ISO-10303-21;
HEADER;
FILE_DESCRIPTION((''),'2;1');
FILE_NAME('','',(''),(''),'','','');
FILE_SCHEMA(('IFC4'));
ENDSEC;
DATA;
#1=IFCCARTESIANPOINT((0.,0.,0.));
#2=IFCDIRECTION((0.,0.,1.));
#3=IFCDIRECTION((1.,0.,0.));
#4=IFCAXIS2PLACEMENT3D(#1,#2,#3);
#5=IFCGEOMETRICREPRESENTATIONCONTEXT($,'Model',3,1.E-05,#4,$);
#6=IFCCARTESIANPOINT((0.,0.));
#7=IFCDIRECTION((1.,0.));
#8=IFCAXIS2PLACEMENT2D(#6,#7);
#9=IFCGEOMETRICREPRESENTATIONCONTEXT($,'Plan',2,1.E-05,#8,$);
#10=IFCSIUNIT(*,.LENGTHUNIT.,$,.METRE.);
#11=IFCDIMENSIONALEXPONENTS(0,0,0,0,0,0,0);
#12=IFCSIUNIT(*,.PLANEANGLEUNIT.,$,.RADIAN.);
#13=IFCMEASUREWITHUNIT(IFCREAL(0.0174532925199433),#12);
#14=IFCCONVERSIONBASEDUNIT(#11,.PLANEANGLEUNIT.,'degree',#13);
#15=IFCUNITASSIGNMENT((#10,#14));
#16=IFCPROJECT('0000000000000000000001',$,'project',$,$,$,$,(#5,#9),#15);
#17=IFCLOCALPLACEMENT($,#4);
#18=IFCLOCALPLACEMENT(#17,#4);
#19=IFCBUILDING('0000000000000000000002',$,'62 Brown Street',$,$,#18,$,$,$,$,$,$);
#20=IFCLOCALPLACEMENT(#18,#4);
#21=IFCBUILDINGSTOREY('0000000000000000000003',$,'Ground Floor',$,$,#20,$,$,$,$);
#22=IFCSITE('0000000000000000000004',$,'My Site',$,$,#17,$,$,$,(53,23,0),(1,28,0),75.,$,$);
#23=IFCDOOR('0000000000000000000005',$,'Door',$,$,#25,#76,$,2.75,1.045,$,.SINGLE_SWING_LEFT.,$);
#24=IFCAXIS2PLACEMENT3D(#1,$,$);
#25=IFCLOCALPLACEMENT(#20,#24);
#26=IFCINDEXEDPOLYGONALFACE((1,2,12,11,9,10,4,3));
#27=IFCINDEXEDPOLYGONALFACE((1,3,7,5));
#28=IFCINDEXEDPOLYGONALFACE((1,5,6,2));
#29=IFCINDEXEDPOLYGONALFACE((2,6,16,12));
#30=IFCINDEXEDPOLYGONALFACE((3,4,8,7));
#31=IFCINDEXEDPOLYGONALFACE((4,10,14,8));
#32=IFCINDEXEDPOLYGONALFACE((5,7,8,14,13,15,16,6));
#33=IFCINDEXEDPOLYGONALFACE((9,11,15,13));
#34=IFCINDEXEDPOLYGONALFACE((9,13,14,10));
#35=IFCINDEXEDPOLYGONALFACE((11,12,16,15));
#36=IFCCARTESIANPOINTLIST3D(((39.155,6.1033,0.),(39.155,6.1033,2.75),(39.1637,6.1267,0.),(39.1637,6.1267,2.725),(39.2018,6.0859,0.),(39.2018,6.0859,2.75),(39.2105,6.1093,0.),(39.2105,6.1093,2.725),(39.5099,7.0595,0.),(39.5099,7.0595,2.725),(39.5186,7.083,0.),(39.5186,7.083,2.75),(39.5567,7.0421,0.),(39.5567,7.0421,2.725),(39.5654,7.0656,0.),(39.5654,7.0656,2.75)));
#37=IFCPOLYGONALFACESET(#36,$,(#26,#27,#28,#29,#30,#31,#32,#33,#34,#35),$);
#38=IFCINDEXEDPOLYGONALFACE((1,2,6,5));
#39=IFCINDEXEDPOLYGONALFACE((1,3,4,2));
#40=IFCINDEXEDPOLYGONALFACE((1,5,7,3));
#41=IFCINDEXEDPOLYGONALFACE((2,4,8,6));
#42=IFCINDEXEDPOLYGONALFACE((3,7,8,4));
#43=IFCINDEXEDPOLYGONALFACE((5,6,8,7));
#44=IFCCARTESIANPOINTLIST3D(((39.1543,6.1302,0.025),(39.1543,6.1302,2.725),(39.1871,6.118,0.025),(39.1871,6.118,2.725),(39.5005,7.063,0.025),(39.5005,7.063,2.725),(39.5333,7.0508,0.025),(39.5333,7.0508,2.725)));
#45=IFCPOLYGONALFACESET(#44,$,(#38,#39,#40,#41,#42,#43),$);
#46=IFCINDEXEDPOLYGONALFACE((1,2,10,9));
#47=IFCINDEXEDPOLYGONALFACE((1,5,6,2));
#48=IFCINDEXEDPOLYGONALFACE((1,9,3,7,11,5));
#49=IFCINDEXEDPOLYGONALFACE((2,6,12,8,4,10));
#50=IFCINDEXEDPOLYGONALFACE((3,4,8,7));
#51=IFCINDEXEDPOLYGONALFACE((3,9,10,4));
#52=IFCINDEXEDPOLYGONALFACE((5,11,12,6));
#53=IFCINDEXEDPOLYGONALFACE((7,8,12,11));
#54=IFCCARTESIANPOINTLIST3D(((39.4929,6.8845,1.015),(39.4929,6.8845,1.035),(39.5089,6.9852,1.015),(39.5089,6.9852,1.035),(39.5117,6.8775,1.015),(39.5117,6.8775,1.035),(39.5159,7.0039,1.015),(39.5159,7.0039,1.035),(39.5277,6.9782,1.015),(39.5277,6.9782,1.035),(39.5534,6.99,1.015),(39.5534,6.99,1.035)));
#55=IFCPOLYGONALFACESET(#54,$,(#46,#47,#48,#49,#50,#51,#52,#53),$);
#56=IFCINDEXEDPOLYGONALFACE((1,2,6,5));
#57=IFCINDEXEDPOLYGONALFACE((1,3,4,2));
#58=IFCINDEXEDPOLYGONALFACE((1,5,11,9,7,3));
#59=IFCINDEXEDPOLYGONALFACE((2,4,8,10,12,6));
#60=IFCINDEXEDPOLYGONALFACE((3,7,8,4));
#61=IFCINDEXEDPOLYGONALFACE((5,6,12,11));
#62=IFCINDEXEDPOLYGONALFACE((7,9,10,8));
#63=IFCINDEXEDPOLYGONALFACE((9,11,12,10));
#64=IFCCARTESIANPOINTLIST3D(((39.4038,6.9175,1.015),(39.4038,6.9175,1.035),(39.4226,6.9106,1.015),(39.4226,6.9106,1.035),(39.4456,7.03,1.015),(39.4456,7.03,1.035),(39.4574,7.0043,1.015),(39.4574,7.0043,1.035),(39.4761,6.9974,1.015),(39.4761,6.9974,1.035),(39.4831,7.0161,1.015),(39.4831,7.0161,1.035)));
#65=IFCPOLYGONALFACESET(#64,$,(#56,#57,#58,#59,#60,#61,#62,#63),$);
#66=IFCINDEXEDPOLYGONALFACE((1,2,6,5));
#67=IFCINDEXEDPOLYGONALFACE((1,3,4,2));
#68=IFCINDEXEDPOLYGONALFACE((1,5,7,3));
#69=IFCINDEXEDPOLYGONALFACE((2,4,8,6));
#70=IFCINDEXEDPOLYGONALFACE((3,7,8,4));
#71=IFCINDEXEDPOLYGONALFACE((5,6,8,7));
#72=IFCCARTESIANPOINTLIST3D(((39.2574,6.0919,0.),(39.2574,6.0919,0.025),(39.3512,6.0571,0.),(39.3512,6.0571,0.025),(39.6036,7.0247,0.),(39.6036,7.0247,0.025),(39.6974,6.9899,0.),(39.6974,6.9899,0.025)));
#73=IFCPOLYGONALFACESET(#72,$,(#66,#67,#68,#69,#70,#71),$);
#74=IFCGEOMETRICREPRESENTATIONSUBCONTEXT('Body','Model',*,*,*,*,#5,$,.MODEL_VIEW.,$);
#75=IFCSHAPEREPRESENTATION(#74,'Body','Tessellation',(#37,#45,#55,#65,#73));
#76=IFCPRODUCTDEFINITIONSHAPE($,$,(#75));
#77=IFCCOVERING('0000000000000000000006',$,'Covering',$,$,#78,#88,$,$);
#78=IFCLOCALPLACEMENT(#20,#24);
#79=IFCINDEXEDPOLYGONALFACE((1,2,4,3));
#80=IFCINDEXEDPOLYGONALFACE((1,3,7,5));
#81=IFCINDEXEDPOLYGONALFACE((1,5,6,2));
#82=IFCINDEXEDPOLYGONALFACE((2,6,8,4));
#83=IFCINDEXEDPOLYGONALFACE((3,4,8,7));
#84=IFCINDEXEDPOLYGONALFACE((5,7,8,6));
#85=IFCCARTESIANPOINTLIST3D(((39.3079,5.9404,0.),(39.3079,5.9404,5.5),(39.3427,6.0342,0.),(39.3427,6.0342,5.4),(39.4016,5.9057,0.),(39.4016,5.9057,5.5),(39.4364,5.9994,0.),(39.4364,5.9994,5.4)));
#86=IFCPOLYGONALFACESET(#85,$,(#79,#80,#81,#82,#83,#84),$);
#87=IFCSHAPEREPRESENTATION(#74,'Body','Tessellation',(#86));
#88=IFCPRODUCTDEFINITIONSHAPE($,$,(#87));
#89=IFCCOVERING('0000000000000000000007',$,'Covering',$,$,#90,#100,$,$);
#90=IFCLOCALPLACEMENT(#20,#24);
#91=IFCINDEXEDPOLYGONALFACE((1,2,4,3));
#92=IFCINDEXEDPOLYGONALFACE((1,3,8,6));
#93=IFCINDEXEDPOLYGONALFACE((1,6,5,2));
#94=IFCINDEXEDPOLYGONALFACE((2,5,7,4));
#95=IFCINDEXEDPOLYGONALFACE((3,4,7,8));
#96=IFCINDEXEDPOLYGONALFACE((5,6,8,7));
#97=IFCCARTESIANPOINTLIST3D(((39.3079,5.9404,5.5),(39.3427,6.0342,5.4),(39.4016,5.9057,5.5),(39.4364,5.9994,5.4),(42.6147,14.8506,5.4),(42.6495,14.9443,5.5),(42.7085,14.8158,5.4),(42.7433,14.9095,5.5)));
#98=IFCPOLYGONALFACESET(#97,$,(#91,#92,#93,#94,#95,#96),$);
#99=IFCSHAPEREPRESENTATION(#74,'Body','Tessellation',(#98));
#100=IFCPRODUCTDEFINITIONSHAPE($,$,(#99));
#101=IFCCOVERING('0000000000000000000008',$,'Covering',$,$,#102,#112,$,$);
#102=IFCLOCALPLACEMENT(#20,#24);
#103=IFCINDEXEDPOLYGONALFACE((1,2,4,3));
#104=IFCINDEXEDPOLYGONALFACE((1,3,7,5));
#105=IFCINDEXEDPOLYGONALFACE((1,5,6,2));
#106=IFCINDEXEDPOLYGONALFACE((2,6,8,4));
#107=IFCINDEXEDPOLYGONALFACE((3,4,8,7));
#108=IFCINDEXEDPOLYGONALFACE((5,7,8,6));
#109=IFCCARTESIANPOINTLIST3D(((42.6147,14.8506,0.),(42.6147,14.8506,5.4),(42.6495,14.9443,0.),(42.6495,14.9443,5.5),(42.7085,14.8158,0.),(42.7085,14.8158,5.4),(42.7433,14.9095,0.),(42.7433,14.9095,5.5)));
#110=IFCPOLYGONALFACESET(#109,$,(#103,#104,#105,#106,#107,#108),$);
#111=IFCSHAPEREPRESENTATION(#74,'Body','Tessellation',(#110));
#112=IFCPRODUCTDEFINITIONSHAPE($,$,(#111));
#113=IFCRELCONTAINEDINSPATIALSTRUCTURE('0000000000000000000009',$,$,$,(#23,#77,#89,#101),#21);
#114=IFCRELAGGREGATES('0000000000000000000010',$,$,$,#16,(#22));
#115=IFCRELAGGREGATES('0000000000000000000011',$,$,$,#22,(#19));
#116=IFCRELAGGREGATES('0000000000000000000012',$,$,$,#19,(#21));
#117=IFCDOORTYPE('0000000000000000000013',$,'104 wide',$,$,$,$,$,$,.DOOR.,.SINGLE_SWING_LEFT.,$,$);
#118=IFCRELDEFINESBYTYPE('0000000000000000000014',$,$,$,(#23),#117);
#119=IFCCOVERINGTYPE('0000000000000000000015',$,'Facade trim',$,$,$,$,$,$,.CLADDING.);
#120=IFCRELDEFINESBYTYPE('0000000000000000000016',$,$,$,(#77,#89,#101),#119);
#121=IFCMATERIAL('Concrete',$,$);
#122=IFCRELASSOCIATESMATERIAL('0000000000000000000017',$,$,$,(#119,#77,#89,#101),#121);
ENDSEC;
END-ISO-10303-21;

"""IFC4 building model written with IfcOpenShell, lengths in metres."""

from ifc_helpers import new_model, entity, si_unit, converted_unit, frame, origin_with_axes, origin_2d_with_axis, place, context, subcontext, project, spatial, line, indexed_curve, rectangle, outline, extrude, clip, halfspace, shape, source, transform, mapped, material, material_profile, profile_set, profile_usage, type_object, type_shapes, element, save


model = new_model("IFC4")

# Units and contexts
model_context = context("Model", 3, precision=1e-05, world=origin_with_axes())
plan_context = context("Plan", 2, precision=1e-05, world=origin_2d_with_axis())
body_context_1 = subcontext(model_context, "Body", "Model", "MODEL_VIEW")
body_context_2 = subcontext(plan_context, "Body", "Plan", "PLAN_VIEW")
ifc_project = project(units=[si_unit("LENGTHUNIT", "METRE"), converted_unit("PLANEANGLEUNIT", "degree", entity("IfcReal", 0.0174532925199433), si_unit("PLANEANGLEUNIT", "RADIAN"), dimensions=[0, 0, 0, 0, 0, 0, 0])], contexts=[model_context, plan_context])

# Site, building, storey
site_placement = place(None, origin_with_axes())
site = spatial("IfcSite", under=ifc_project, at=site_placement, Name="My Site", RefLatitude=(53, 23, 0), RefLongitude=(1, 28, 0), RefElevation=75.0)
building_placement = place(site_placement, origin_with_axes())
building = spatial("IfcBuilding", under=site, at=building_placement, Name="62 Brown Street")
storey_placement = place(building_placement, origin_with_axes())
storey = spatial("IfcBuildingStorey", under=building, at=storey_placement, Name="Ground Floor")

# Shared definitions
ifc_material_1 = material(Name="Concrete")

# Shared definitions
placement_1 = place(storey_placement, frame((39.024, 5.1755, 0.0), z_axis=(0.0, 0.0, 1.0), x_axis=(0.347944, 0.937515, 0.0)))

# Door
door_type_1 = type_object("IfcDoorType", Name="104 wide", OperationType="SINGLE_SWING_LEFT", PredefinedType="DOOR")
shared_shape_1 = source(origin_with_axes(), body_context_1, "Body", "SweptSolid", [
    extrude(outline(indexed_curve([(0.0, 0.0), (0.0, 2.75), (1.045, 2.75), (1.045, 0.0), (1.02, 0.0), (1.02, 2.725), (0.025, 2.725), (0.025, 0.0)], segments=[line(1, 2, 3, 4, 5, 6, 7, 8, 1)])), frame((0.0, 0.15, 0.0), z_axis=(0.0, -1.0, 0.0), x_axis=(1.0, 0.0, 0.0)), (0.0, 0.0, -1.0), 0.05),
    extrude(outline(indexed_curve([(0.0, 0.0), (0.995, 0.0), (0.995, 0.035), (0.0, 0.035)], segments=[line(1, 2, 3, 4, 1)])), frame((0.025, 0.175, 0.025), z_axis=(0.0, 0.0, 1.0), x_axis=(1.0, 0.0, 0.0)), (0.0, 0.0, 1.0), 2.7),
    extrude(outline(indexed_curve([(0.0, 0.0), (0.0, -0.04), (-0.12, -0.04), (-0.12, -0.02), (-0.02, -0.02), (-0.02, 0.0)], segments=[line(1, 2, 3, 4, 5, 6, 1)])), frame((0.97, 0.175, 1.015), z_axis=(0.0, 0.0, 1.0), x_axis=(1.0, 0.0, 0.0)), (0.0, 0.0, 1.0), 0.02),
    extrude(outline(indexed_curve([(0.0, 0.0), (0.0, 0.04), (-0.12, 0.04), (-0.12, 0.02), (-0.02, 0.02), (-0.02, 0.0)], segments=[line(1, 2, 3, 4, 5, 6, 1)])), frame((0.97, 0.21, 1.015), z_axis=(0.0, 0.0, 1.0), x_axis=(1.0, 0.0, 0.0)), (0.0, 0.0, 1.0), 0.02),
    extrude(outline(indexed_curve([(0.0, 0.0), (0.995, 0.0), (0.995, 0.1), (0.0, 0.1)], segments=[line(1, 2, 3, 4, 1)])), frame((0.025, 0.0, 0.0), z_axis=(0.0, 0.0, 1.0), x_axis=(1.0, 0.0, 0.0)), (0.0, 0.0, 1.0), 0.025),
])
shared_shape_2 = source(origin_with_axes(), body_context_2, "Body", "Curve2D", [
    entity("IfcIndexedPolyCurve", entity("IfcCartesianPointList2D", [[0.0, 0.15], [0.025, 0.15], [0.025, 0.2], [0.0, 0.2]]), [entity("IfcLineIndex", [1, 2, 3, 4, 1])]),
    entity("IfcIndexedPolyCurve", entity("IfcCartesianPointList2D", [[1.045, 0.15], [1.02, 0.15], [1.02, 0.2], [1.045, 0.2]]), [entity("IfcLineIndex", [1, 2, 3, 4, 1])]),
    entity("IfcTrimmedCurve", entity("IfcEllipse", entity("IfcAxis2Placement2D", entity("IfcCartesianPoint", [0.06, 0.2]), entity("IfcDirection", [1.0, 0.0])), 0.96, 0.995), [entity("IfcCartesianPoint", [1.02, 0.2])], [entity("IfcCartesianPoint", [0.06, 1.195])], True, "CARTESIAN"),
    entity("IfcIndexedPolyCurve", entity("IfcCartesianPointList2D", [[0.025, 0.2], [0.06, 0.2], [0.06, 1.195], [0.025, 1.195]]), [entity("IfcLineIndex", [1, 2, 3, 4, 1])]),
])
type_shapes(door_type_1, [shared_shape_1, shared_shape_2])
placement_2 = place(placement_1, frame((0.9154, 0.0, 0.0), z_axis=(0.0, 0.0, 1.0), x_axis=(1.0, 0.0, 0.0)))
door_1_placement = place(placement_2, frame((0.0, 0.0, 0.0), z_axis=(0.0, 0.0, 1.0), x_axis=(1.0, 0.0, 0.0)))
element("IfcDoor", 1, at=door_1_placement, inside=storey, type_object=door_type_1, Name="Door", OperationType="SINGLE_SWING_LEFT", OverallHeight=2.75, OverallWidth=1.045, shapes=[
    shape(body_context_1, "Body", "MappedRepresentation", [mapped(shared_shape_1, transform((0.0, 0.0, 0.0), x_axis=(1.0, 0.0, 0.0), y_axis=(0.0, 1.0, 0.0), z_axis=(0.0, 0.0, 1.0), scale=1.0))]),
    shape(body_context_2, "Body", "MappedRepresentation", [mapped(shared_shape_2, transform((0.0, 0.0, 0.0), x_axis=(1.0, 0.0, 0.0), y_axis=(0.0, 1.0, 0.0), z_axis=(0.0, 0.0, 1.0), scale=1.0))]),
])

# Coverings
ifc_material_profile_1 = material_profile(ifc_material_1, rectangle(XDim=0.1, YDim=0.1))
ifc_profile_set_1 = profile_set([ifc_material_profile_1], Name="cowl")
ifc_profile_usage_1 = profile_usage(ifc_profile_set_1, cardinal=5)
covering_type = type_object("IfcCoveringType", Name="Facade trim", PredefinedType="CLADDING", material=ifc_profile_set_1)
covering_1_placement = place(storey_placement, frame((39.3721, 5.9699, 0.0), z_axis=(0.0, 0.0, 1.0), x_axis=(0.347944, 0.937515, 0.0)))
element("IfcCovering", 2, at=covering_1_placement, inside=storey, type_object=covering_type, material=ifc_profile_usage_1, Name="Covering", context=body_context_1, shape_type="Clipping", body=[
    clip(extrude(rectangle(XDim=0.1, YDim=0.1), origin_with_axes(), (0.0, 0.0, 1.0), 5.5), halfspace(frame((-0.05, 34.8348, 5.5), z_axis=(0.707098, 0.0, 0.707116), x_axis=(0.707116, 0.0, -0.707098)), False)),
])
ifc_profile_usage_2 = profile_usage(ifc_profile_set_1, cardinal=5)
covering_2_placement = place(storey_placement, frame((39.3547, 5.923, 5.45), z_axis=(0.347944, 0.937515, 0.0), x_axis=(0.0, 0.0, -1.0)))
element("IfcCovering", 3, at=covering_2_placement, inside=storey, type_object=covering_type, material=ifc_profile_usage_2, Name="Covering", context=body_context_1, shape_type="Clipping", body=[
    clip(clip(extrude(rectangle(XDim=0.1, YDim=0.1), origin_with_axes(), (0.0, 0.0, 1.0), 9.604), halfspace(frame((-0.05, 34.8348, 9.604), z_axis=(0.707114, 0.0, 0.7071), x_axis=(0.7071, -0.000003, -0.707113)), False)), halfspace(frame((-0.05, 34.8348, 0.0), z_axis=(0.707116, 0.0, -0.707098), x_axis=(0.707098, 0.0, 0.707116)), False)),
])
ifc_profile_usage_3 = profile_usage(ifc_profile_set_1, cardinal=5)
covering_3_placement = place(storey_placement, frame((42.679, 14.8801, 5.5), z_axis=(0.0, 0.0, -1.0), x_axis=(-0.347944, -0.937515, 0.0)))
element("IfcCovering", 4, at=covering_3_placement, inside=storey, type_object=covering_type, material=ifc_profile_usage_3, Name="Covering", context=body_context_1, shape_type="Clipping", body=[
    clip(extrude(rectangle(XDim=0.1, YDim=0.1), origin_with_axes(), (0.0, 0.0, 1.0), 5.5), halfspace(frame((-0.05, 34.8348, 0.0), z_axis=(0.7071, 0.0, -0.707113), x_axis=(0.707113, -0.000003, 0.7071)), False)),
])

save(model, "model.ifc")
